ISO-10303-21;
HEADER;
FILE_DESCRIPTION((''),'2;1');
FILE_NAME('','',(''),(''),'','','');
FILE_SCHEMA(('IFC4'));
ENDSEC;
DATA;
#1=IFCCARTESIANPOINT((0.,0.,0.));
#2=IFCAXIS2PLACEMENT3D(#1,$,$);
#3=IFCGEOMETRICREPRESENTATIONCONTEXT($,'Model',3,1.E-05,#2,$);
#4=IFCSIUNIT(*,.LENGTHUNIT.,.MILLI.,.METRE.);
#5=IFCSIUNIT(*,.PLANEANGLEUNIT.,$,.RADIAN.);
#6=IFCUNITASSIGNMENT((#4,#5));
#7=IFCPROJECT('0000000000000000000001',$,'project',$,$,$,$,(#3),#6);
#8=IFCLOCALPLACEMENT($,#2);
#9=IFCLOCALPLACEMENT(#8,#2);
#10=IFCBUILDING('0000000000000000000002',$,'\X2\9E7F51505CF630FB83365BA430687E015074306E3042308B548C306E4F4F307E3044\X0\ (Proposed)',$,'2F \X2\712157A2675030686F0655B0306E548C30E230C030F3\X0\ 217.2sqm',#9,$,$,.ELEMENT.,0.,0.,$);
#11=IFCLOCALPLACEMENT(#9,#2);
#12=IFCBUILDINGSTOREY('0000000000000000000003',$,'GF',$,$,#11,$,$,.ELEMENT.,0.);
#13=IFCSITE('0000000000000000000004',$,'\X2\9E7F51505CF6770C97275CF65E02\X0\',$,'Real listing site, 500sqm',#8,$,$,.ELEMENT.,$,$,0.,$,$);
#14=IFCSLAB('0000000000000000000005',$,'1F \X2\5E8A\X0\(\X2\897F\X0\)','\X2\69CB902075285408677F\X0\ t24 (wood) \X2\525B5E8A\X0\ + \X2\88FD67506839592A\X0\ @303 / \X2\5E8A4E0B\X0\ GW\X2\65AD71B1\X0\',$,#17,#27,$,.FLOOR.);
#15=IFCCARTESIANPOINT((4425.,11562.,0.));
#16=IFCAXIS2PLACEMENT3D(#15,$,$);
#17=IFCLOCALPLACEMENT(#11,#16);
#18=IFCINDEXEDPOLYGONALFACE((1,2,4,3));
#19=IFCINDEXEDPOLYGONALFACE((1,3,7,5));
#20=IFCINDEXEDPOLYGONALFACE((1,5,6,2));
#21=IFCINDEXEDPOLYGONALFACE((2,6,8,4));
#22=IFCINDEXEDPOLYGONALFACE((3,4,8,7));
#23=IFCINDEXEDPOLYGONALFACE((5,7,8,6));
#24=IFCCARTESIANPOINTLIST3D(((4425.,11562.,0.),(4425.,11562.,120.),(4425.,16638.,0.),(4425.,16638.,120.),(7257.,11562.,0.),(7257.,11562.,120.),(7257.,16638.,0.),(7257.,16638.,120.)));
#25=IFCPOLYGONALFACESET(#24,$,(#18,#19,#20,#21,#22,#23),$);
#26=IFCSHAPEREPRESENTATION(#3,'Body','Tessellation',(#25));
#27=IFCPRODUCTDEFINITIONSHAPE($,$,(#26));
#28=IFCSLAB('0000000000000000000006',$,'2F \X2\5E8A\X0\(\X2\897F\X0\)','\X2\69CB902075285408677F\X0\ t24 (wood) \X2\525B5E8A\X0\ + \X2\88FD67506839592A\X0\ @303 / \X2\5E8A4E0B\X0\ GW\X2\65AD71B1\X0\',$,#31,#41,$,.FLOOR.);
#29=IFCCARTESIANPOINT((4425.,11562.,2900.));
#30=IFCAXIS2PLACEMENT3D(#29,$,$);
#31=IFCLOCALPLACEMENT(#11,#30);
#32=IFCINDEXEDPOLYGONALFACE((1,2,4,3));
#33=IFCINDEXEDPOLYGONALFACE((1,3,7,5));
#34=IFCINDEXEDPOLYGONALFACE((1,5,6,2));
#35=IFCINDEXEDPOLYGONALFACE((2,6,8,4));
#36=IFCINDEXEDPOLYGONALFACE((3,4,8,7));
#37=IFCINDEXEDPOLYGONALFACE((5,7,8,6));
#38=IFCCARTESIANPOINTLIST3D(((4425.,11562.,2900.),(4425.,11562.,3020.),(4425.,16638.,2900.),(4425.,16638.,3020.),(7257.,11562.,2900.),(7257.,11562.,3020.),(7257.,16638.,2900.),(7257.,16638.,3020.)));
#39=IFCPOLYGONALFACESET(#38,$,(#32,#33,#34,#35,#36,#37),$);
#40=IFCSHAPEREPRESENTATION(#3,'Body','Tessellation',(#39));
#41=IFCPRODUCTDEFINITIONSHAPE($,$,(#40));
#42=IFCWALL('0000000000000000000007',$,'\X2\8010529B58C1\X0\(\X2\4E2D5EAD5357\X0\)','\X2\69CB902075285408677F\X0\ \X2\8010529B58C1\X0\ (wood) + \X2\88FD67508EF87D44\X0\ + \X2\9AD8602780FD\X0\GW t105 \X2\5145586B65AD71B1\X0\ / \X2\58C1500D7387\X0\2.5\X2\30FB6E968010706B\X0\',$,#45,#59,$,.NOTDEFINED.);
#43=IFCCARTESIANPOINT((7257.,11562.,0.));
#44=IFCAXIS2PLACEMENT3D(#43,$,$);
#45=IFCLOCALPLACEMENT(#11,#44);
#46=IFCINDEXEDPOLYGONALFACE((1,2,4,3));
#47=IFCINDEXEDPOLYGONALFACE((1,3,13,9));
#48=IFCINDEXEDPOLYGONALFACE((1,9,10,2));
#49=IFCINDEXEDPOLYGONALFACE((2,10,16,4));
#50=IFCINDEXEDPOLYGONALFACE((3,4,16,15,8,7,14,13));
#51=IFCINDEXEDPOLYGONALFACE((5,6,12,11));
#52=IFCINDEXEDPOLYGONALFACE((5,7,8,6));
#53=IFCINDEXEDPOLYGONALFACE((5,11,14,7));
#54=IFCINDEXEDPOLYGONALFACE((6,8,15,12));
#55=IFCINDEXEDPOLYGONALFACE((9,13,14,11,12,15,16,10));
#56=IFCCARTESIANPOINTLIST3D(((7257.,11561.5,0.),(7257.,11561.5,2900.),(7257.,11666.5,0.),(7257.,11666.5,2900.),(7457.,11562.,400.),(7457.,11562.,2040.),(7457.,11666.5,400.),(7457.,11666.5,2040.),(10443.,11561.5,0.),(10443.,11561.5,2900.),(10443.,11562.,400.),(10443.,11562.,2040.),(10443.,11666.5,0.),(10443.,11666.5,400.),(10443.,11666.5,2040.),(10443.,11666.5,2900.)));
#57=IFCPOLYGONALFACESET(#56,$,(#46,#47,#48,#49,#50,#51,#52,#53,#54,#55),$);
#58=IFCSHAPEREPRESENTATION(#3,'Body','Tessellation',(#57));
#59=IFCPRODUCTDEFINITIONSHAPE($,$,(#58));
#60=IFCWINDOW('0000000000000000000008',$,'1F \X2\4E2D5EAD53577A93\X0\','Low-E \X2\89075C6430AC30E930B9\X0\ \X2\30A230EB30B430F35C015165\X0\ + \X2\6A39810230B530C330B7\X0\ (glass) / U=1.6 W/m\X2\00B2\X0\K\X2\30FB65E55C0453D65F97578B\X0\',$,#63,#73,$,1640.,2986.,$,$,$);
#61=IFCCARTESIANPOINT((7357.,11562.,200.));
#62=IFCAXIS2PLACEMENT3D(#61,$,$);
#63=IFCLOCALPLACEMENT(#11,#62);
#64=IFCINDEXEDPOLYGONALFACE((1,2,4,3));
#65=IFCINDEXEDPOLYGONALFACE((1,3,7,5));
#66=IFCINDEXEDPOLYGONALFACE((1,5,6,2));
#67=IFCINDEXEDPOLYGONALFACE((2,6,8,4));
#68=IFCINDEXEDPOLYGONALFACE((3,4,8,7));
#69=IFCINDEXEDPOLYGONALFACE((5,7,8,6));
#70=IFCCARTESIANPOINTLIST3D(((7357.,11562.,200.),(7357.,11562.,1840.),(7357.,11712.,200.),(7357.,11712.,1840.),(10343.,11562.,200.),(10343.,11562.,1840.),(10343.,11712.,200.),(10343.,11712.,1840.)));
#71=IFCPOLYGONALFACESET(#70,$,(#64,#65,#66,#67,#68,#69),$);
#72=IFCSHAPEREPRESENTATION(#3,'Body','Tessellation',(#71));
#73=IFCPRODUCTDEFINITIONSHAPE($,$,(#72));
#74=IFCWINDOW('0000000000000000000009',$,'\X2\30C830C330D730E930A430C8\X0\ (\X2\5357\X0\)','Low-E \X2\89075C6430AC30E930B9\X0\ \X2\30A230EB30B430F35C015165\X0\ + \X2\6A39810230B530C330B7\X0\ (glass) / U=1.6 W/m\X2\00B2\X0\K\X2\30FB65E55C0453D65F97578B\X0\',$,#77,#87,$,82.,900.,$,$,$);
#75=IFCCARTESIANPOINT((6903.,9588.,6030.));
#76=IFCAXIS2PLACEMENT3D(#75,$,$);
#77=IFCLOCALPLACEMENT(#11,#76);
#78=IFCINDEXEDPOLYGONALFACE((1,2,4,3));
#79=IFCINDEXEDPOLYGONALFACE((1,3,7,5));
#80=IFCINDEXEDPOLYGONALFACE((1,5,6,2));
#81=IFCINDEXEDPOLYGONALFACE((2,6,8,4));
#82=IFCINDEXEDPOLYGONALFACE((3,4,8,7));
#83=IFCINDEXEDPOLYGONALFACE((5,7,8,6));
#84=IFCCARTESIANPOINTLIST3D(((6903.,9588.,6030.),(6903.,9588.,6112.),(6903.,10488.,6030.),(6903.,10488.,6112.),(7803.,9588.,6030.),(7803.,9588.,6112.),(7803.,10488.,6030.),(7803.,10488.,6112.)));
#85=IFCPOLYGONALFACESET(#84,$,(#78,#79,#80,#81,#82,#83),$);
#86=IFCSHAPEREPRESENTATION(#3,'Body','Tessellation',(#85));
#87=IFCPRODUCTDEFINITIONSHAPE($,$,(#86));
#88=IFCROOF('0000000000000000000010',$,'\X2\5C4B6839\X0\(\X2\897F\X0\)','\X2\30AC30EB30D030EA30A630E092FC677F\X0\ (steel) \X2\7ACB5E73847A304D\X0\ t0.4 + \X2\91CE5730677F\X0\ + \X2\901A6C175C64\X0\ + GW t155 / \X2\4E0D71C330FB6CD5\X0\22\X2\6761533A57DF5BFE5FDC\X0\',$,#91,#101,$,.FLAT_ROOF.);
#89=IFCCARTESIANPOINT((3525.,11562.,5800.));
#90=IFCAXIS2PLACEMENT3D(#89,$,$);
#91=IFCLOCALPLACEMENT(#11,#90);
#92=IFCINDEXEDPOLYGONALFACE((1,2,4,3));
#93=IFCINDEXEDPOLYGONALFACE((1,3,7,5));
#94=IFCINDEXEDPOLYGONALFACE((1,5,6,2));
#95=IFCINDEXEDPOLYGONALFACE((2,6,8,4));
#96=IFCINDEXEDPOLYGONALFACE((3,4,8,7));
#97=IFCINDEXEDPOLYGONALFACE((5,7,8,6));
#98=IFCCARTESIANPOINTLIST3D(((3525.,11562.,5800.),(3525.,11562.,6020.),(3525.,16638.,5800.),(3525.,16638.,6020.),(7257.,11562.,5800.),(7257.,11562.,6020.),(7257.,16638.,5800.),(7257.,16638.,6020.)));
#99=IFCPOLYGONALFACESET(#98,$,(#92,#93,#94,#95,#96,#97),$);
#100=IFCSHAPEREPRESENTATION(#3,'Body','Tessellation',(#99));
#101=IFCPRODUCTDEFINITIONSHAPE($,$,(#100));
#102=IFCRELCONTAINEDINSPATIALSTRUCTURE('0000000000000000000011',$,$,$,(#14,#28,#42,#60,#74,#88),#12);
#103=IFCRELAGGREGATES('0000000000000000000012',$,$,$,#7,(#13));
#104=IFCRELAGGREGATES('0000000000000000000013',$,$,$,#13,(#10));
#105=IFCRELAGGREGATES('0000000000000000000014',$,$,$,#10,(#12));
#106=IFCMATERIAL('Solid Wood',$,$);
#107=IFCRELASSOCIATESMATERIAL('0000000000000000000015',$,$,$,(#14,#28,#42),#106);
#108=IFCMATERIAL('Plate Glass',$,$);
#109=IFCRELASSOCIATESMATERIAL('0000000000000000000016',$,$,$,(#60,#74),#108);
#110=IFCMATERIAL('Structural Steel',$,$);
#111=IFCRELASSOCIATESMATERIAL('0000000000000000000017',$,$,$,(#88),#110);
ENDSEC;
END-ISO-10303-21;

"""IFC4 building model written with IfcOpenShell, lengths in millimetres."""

from ifc_helpers import new_model, si_unit, frame, frame_2d, origin, place, context, project, spatial, rectangle, extrude, material, element, fill, save


model = new_model("IFC4")

# Units and contexts
model_context = context("Model", 3, precision=1e-05, world=origin())
ifc_project = project(units=[si_unit("LENGTHUNIT", "METRE", prefix="MILLI"), si_unit("PLANEANGLEUNIT", "RADIAN")], contexts=[model_context])

# Site, building, storey
site_placement = place(None, origin())
site = spatial("IfcSite", under=ifc_project, at=site_placement, Name="鹿児島県霧島市", ObjectType="Real listing site, 500sqm", CompositionType="ELEMENT", RefElevation=0.0)
building_placement = place(site_placement, origin())
building = spatial("IfcBuilding", under=site, at=building_placement, Name="鹿児島・茶室と縁側のある和の住まい (Proposed)", ObjectType="2F 無垢材と漆喰の和モダン 217.2sqm", CompositionType="ELEMENT", ElevationOfRefHeight=0.0, ElevationOfTerrain=0.0)
storey_placement = place(building_placement, origin())
storey = spatial("IfcBuildingStorey", under=building, at=storey_placement, Name="GF", CompositionType="ELEMENT", Elevation=0.0)

# Shared definitions
ifc_material_1 = material(Name="Solid Wood")

# Slabs
slab_1_placement = place(storey_placement, frame((4425.0, 11562.0, 0.0)))
element("IfcSlab", 1, at=slab_1_placement, inside=storey, material=ifc_material_1, Name="1F 床(西)", Description="構造用合板 t24 (wood) 剛床 + 製材根太 @303 / 床下 GW断熱", PredefinedType="FLOOR", context=model_context, shape_type="SweptSolid", body=[
    extrude(rectangle(XDim=2832.0, YDim=5076.0, at=frame_2d((1416.0, 2538.0))), frame((4425.0, 11562.0, 0.0)), (0.0, 0.0, 1.0), 120.0),
])
slab_2_placement = place(storey_placement, frame((4425.0, 11562.0, 2900.0)))
element("IfcSlab", 2, at=slab_2_placement, inside=storey, material=ifc_material_1, Name="2F 床(西)", Description="構造用合板 t24 (wood) 剛床 + 製材根太 @303 / 床下 GW断熱", PredefinedType="FLOOR", context=model_context, shape_type="SweptSolid", body=[
    extrude(rectangle(XDim=2832.0, YDim=5076.0, at=frame_2d((1416.0, 2538.0))), frame((4425.0, 11562.0, 2900.0)), (0.0, 0.0, 1.0), 120.0),
])

# Wall, opening, window
wall_placement = place(storey_placement, frame((7257.0, 11562.0, 0.0)))
wall = element("IfcWall", 3, at=wall_placement, inside=storey, material=ifc_material_1, Name="耐力壁(中庭南)", Description="構造用合板 耐力壁 (wood) + 製材軸組 + 高性能GW t105 充填断熱 / 壁倍率2.5・準耐火", PredefinedType="NOTDEFINED", context=model_context, shape_type="SweptSolid", body=[
    extrude(rectangle(XDim=3186.0, YDim=105.0, at=frame_2d((1593.0, 52.0))), frame((7257.0, 11562.0, 0.0)), (0.0, 0.0, 1.0), 2900.0),
])
opening_placement = place(storey_placement, frame((7357.0, 11562.0, 200.0)))
opening = element("IfcOpeningElement", 4, at=opening_placement, cuts=wall, PredefinedType="NOTDEFINED", context=model_context, shape_type="SweptSolid", body=[
    extrude(rectangle(XDim=2986.0, YDim=150.0, at=frame_2d((1493.0, 75.0))), frame((7357.0, 11562.0, 200.0)), (0.0, 0.0, 1.0), 1640.0),
])
ifc_material_2 = material(Name="Plate Glass")
window_1_placement = place(storey_placement, frame((7357.0, 11562.0, 200.0)))
window_1 = element("IfcWindow", 5, at=window_1_placement, inside=storey, material=ifc_material_2, Name="1F 中庭南窓", Description="Low-E 複層ガラス アルゴン封入 + 樹脂サッシ (glass) / U=1.6 W/m²K・日射取得型", OverallHeight=1640.0, OverallWidth=2986.0, context=model_context, shape_type="SweptSolid", body=[
    extrude(rectangle(XDim=2986.0, YDim=150.0, at=frame_2d((1493.0, 75.0))), frame((7357.0, 11562.0, 200.0)), (0.0, 0.0, 1.0), 1640.0),
])
fill(opening, window_1)

# Window
window_2_placement = place(storey_placement, frame((6903.0, 9588.0, 6030.0)))
element("IfcWindow", 6, at=window_2_placement, inside=storey, material=ifc_material_2, Name="トップライト (南)", Description="Low-E 複層ガラス アルゴン封入 + 樹脂サッシ (glass) / U=1.6 W/m²K・日射取得型", OverallHeight=82.0, OverallWidth=900.0, context=model_context, shape_type="SweptSolid", body=[
    extrude(rectangle(XDim=900.0, YDim=900.0, at=frame_2d((450.0, 450.0))), frame((6903.0, 9588.0, 6030.0)), (0.0, 0.0, 1.0), 82.0),
])

# Roof
ifc_material_3 = material(Name="Structural Steel")
for number, where, name in (
    (7, (3525.0, 11562.0, 5800.0), "屋根(西)"),
):
    element("IfcRoof", number, at=place(storey_placement, frame(where)), inside=storey, material=ifc_material_3, Name=name, Description="ガルバリウム鋼板 (steel) 立平葺き t0.4 + 野地板 + 通気層 + GW t155 / 不燃・法22条区域対応", PredefinedType="FLAT_ROOF", context=model_context, shape_type="SweptSolid", body=[
        extrude(rectangle(XDim=3732.0, YDim=5076.0, at=frame_2d((1866.0, 2538.0))), frame((3525.0, 11562.0, 5800.0)), (0.0, 0.0, 1.0), 220.0),
    ])

save(model, "model.ifc")
